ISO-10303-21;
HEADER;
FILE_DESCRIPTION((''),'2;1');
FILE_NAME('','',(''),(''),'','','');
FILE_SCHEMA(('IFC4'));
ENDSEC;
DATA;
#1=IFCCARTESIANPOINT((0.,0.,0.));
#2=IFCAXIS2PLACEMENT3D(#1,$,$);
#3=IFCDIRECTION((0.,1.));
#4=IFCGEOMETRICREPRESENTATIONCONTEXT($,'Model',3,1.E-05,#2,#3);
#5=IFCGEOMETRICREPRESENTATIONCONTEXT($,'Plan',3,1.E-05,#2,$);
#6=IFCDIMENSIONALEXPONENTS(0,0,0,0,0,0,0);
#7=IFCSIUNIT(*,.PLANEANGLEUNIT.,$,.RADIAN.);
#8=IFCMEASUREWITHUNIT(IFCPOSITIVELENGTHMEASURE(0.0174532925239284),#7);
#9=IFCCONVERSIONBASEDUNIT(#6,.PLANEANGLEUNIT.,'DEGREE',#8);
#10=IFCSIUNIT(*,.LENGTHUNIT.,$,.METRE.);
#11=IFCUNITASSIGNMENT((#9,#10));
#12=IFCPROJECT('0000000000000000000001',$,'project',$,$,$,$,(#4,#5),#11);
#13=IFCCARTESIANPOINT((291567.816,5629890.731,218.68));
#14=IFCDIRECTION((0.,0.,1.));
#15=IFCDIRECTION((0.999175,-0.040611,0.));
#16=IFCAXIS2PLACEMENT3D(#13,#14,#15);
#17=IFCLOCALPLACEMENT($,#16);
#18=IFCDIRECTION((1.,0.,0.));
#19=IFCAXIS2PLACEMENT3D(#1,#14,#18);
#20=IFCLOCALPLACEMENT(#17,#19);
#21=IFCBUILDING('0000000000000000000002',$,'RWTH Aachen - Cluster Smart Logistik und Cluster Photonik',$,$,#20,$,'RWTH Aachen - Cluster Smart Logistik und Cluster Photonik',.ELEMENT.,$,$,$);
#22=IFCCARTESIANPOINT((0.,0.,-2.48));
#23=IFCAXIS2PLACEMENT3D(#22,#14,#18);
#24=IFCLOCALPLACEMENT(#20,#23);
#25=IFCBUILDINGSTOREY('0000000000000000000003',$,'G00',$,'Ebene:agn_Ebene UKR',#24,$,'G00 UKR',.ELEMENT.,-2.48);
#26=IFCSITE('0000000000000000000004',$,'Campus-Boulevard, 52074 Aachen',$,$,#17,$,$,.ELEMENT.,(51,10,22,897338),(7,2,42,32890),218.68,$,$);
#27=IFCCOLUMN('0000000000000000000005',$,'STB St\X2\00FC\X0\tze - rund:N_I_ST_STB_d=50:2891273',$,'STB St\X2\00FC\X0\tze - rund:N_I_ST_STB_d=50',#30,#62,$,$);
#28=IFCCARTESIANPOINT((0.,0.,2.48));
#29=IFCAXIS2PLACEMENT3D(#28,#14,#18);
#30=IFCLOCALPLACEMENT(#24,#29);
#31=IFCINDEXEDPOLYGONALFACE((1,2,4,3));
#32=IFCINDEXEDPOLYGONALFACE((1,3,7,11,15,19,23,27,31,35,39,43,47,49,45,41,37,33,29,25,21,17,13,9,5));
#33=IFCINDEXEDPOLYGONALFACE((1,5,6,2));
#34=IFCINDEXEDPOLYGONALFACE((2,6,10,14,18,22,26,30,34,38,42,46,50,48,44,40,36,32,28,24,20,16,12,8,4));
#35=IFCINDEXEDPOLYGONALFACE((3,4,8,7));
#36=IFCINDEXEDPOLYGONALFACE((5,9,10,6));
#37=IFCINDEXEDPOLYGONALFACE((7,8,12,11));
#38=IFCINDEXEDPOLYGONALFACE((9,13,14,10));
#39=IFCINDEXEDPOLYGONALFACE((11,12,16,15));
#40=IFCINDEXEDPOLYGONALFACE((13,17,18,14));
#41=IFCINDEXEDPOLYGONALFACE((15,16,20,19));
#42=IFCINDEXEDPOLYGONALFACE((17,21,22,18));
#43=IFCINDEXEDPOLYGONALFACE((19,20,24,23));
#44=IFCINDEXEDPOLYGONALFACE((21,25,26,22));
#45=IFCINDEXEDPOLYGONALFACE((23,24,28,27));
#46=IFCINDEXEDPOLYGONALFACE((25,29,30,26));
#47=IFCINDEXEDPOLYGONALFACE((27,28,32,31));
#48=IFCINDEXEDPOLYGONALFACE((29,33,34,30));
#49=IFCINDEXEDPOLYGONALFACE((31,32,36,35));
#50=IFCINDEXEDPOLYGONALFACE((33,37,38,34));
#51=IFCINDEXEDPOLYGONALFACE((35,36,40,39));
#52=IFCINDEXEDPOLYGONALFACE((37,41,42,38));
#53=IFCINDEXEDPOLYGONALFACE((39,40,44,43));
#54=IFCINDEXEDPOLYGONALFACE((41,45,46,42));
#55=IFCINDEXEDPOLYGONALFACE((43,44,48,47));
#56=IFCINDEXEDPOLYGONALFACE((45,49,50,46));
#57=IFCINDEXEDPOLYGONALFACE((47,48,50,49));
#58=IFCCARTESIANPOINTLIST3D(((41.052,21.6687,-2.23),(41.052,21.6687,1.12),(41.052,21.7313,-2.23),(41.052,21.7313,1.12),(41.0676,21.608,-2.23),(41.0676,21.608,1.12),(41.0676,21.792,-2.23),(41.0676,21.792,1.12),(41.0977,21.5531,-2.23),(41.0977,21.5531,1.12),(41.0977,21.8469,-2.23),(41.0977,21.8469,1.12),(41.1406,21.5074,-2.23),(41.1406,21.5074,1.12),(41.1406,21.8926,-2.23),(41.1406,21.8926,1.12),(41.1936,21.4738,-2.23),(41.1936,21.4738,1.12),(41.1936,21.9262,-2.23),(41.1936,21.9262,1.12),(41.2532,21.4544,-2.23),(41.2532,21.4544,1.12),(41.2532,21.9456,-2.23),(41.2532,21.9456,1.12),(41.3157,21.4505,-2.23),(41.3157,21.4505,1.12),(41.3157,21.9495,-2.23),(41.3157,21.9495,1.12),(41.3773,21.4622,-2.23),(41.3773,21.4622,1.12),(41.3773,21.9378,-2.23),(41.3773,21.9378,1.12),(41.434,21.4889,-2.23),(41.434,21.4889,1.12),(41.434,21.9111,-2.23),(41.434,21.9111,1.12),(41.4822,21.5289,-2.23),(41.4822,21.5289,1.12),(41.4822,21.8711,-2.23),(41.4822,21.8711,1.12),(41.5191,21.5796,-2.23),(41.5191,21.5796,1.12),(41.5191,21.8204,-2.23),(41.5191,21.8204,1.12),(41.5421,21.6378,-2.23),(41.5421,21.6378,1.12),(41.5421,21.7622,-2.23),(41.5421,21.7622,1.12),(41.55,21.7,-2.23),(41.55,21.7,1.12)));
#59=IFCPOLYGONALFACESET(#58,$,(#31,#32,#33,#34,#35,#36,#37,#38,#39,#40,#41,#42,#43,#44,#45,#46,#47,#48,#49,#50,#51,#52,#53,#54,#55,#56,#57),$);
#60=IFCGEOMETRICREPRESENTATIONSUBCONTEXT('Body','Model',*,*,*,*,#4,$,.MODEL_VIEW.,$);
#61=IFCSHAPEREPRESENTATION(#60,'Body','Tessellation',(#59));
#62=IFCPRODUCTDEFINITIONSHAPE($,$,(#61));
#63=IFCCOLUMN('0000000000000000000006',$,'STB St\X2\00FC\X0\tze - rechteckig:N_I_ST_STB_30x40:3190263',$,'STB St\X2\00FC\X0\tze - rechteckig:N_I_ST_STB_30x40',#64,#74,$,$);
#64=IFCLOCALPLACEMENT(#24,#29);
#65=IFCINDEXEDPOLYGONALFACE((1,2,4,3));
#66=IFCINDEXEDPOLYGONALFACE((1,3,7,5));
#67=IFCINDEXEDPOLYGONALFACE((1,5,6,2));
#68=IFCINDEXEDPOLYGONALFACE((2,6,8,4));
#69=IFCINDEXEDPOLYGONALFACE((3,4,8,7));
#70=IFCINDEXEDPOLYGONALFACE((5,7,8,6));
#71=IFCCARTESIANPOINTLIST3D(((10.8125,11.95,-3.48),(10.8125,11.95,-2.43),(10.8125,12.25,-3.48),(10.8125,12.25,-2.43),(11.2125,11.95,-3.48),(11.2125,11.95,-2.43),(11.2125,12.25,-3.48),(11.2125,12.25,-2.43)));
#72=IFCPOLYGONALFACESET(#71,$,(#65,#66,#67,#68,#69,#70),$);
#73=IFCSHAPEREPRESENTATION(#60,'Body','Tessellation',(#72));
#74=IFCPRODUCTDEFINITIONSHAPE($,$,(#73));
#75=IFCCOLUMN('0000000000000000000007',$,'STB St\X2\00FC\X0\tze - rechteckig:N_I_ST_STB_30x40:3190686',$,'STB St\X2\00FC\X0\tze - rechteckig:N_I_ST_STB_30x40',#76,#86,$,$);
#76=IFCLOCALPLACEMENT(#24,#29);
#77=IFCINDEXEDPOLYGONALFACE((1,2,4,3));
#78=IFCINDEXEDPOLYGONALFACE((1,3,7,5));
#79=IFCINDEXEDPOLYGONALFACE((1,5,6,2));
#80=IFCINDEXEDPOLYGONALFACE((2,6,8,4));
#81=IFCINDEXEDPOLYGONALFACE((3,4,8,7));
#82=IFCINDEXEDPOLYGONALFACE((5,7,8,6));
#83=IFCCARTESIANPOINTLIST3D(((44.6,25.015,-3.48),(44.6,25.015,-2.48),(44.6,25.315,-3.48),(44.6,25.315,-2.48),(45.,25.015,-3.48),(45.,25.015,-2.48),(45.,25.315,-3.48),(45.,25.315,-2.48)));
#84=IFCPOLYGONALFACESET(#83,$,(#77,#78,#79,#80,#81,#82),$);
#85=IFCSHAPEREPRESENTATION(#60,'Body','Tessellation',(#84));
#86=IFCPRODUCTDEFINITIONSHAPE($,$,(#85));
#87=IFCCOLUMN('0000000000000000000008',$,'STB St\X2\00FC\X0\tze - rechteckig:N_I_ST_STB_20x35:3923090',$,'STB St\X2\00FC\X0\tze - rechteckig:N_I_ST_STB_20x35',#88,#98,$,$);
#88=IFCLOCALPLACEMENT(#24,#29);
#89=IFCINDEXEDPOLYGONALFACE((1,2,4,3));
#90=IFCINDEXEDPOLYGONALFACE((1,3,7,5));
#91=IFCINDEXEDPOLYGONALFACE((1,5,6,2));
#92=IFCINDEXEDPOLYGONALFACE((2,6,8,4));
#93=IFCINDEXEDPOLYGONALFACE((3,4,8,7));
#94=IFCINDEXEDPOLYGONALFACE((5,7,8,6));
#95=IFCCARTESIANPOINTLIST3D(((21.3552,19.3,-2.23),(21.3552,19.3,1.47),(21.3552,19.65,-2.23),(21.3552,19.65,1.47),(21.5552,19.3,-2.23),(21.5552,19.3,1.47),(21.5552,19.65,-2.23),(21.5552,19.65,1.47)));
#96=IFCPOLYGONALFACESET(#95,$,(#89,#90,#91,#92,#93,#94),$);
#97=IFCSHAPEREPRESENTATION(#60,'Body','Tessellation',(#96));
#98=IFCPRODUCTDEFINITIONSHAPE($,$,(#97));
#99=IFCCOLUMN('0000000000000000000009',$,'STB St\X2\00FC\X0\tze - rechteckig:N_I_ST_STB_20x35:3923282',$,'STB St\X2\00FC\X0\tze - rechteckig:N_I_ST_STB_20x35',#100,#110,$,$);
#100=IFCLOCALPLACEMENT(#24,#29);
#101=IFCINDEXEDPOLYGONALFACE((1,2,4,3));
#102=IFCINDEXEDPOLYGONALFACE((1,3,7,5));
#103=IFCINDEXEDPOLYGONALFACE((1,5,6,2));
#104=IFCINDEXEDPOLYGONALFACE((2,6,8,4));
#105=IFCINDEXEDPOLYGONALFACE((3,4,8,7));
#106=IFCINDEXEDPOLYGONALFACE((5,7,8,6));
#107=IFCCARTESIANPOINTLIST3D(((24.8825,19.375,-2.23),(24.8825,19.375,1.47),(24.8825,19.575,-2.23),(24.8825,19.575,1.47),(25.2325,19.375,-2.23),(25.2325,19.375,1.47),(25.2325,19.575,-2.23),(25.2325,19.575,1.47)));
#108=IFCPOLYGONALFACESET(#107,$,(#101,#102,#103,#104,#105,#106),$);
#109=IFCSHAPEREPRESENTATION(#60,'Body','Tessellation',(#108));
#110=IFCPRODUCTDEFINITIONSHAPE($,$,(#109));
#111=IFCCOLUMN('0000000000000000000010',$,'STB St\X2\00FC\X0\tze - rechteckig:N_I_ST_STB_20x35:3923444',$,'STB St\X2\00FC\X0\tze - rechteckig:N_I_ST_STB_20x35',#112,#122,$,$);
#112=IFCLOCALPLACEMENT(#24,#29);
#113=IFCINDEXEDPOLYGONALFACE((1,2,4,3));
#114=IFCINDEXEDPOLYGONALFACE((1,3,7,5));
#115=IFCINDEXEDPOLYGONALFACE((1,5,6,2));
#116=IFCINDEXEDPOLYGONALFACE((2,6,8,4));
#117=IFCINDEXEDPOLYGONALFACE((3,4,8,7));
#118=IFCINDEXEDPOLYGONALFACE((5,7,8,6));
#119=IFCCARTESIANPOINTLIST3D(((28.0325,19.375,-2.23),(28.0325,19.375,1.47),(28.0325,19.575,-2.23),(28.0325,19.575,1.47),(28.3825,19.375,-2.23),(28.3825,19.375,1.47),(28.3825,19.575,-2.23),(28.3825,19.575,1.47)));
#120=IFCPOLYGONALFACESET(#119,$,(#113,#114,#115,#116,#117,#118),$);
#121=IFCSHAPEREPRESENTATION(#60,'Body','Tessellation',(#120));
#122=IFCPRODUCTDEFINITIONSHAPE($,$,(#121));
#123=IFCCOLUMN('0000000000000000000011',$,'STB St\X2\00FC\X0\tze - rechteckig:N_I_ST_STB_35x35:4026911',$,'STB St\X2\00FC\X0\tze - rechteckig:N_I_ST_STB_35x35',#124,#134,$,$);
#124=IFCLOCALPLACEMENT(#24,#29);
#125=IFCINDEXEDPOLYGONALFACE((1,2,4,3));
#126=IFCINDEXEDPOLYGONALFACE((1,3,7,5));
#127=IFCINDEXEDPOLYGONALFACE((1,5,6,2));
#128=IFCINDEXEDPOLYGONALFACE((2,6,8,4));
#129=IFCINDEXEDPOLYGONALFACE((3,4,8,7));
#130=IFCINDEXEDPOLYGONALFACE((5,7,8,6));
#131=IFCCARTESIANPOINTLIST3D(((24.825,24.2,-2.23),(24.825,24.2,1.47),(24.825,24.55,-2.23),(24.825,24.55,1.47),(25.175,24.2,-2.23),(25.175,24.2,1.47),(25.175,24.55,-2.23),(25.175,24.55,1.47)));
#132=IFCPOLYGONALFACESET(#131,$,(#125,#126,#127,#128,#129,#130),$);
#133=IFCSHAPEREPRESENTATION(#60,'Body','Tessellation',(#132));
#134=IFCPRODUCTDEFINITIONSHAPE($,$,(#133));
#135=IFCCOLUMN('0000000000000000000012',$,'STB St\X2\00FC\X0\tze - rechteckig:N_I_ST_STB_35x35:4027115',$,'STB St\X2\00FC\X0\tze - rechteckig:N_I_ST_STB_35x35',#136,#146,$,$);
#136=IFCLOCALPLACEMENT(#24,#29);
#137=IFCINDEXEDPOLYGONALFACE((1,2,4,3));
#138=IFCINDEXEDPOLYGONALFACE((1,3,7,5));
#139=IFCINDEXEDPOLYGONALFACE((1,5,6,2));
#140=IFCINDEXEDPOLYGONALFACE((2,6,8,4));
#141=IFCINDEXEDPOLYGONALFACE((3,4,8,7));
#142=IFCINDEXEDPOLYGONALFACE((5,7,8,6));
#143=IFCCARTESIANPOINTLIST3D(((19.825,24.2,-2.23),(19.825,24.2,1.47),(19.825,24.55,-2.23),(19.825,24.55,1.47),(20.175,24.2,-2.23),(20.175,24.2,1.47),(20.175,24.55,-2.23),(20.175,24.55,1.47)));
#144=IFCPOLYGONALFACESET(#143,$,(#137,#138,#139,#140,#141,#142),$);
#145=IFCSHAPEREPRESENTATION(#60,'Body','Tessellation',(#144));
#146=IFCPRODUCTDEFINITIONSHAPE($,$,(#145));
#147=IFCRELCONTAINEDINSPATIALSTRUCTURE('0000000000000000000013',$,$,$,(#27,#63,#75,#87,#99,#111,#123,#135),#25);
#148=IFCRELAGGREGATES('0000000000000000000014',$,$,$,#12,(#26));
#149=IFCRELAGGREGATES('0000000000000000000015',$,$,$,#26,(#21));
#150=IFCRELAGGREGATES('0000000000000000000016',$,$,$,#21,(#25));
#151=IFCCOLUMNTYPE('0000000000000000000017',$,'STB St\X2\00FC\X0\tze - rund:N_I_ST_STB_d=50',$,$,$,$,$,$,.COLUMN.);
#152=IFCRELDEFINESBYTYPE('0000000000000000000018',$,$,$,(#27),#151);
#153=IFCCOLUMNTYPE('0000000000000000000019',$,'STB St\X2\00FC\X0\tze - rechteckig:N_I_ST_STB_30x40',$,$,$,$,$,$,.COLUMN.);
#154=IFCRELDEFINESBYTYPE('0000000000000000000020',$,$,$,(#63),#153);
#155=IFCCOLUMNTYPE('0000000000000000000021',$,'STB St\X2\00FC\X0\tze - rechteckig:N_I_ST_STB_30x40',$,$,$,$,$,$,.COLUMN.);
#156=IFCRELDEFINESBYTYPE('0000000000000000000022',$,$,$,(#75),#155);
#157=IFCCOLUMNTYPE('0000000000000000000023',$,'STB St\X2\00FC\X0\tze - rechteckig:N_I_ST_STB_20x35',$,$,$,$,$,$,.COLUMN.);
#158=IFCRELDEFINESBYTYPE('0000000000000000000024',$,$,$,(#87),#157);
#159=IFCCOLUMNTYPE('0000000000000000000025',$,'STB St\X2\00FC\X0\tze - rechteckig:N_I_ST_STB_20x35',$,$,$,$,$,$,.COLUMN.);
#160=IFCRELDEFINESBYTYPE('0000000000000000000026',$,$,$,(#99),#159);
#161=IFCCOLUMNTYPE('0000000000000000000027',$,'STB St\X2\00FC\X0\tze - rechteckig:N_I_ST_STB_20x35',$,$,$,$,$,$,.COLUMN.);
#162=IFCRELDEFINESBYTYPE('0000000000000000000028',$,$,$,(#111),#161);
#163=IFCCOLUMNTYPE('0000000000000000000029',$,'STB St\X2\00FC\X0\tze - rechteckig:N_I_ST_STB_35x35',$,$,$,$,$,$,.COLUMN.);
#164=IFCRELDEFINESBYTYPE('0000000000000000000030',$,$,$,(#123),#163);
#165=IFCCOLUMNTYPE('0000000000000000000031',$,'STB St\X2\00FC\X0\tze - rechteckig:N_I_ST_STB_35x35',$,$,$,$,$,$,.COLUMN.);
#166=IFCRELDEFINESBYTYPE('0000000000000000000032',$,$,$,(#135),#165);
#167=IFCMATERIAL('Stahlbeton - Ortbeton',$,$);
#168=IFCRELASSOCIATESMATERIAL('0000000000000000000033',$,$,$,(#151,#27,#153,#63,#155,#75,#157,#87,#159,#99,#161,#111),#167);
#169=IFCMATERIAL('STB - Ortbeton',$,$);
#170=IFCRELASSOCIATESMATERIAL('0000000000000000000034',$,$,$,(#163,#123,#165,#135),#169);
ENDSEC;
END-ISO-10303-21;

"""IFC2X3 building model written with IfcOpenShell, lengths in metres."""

from ifc_helpers import new_model, entity, si_unit, converted_unit, direction, frame, frame_2d, origin, origin_with_axes, origin_2d_with_axis, place, context, subcontext, project, spatial, rectangle, circle, extrude, source, transform, mapped, material, type_object, element, save


model = new_model("IFC2X3")

# Units and contexts
model_context = context("Model", 3, precision=1e-05, world=origin(), true_north=direction((0.0, 1.0)))
plan_context = context("Plan", 3, precision=1e-05, world=origin())
body_context = subcontext(model_context, "Body", "Model", "MODEL_VIEW")
ifc_project = project(units=[converted_unit("PLANEANGLEUNIT", "DEGREE", entity("IfcPositiveLengthMeasure", 0.0174532925239284), si_unit("PLANEANGLEUNIT", "RADIAN"), dimensions=[0, 0, 0, 0, 0, 0, 0]), si_unit("LENGTHUNIT", "METRE")], contexts=[model_context, plan_context])

# Site, building, storey
site_placement = place(None, frame((291567.816, 5629890.731, 218.68), z_axis=(0.0, 0.0, 1.0), x_axis=(0.999175, -0.040611, 0.0)))
site = spatial("IfcSite", under=ifc_project, at=site_placement, Name="Campus-Boulevard, 52074 Aachen", CompositionType="ELEMENT", RefLatitude=(51, 10, 22, 897338), RefLongitude=(7, 2, 42, 32890), RefElevation=218.68)
building_placement = place(site_placement, origin_with_axes())
building = spatial("IfcBuilding", under=site, at=building_placement, Name="RWTH Aachen - Cluster Smart Logistik und Cluster Photonik", LongName="RWTH Aachen - Cluster Smart Logistik und Cluster Photonik", CompositionType="ELEMENT")
storey_placement = place(building_placement, frame((0.0, 0.0, -2.48), z_axis=(0.0, 0.0, 1.0), x_axis=(1.0, 0.0, 0.0)))
storey = spatial("IfcBuildingStorey", under=building, at=storey_placement, Name="G00", ObjectType="Ebene:agn_Ebene UKR", LongName="G00 UKR", CompositionType="ELEMENT", Elevation=-2.48)

# Shared definitions
ifc_material_1 = material(Name="STB - Ortbeton")

# Columns
ifc_material_2 = material(Name="Stahlbeton - Ortbeton")
column_type_1 = type_object("IfcColumnType", Name="STB Stütze - rund:N_I_ST_STB_d=50", PredefinedType="COLUMN", material=ifc_material_2)
shared_shape_1 = source(origin(), body_context, "Body", "SweptSolid", [
    extrude(circle(Radius=0.25, at=origin_2d_with_axis()), frame((41.3, 21.7, -2.23)), (0.0, 0.0, 1.0), 3.35),
])
column_1_placement = place(storey_placement, frame((0.0, 0.0, 2.48), z_axis=(0.0, 0.0, 1.0), x_axis=(1.0, 0.0, 0.0)))
element("IfcColumn", 1, at=column_1_placement, inside=storey, type_object=column_type_1, material=ifc_material_2, Name="STB Stütze - rund:N_I_ST_STB_d=50:2891273", ObjectType="STB Stütze - rund:N_I_ST_STB_d=50", context=body_context, shape_type="MappedRepresentation", body=[
    mapped(shared_shape_1, transform((0.0, 0.0, 0.0), scale=1.0)),
])
column_type_2 = type_object("IfcColumnType", Name="STB Stütze - rechteckig:N_I_ST_STB_30x40", PredefinedType="COLUMN", material=ifc_material_2)
shared_shape_2 = source(origin(), body_context, "Body", "SweptSolid", [
    extrude(rectangle(XDim=0.3, YDim=0.4, at=origin_2d_with_axis()), frame((11.0125, 12.1, -3.48), z_axis=(0.0, 0.0, 1.0), x_axis=(0.0, -1.0, 0.0)), (0.0, 0.0, 1.0), 1.05),
])
column_2_placement = place(storey_placement, frame((0.0, 0.0, 2.48), z_axis=(0.0, 0.0, 1.0), x_axis=(1.0, 0.0, 0.0)))
element("IfcColumn", 2, at=column_2_placement, inside=storey, type_object=column_type_2, material=ifc_material_2, Name="STB Stütze - rechteckig:N_I_ST_STB_30x40:3190263", ObjectType="STB Stütze - rechteckig:N_I_ST_STB_30x40", context=body_context, shape_type="MappedRepresentation", body=[
    mapped(shared_shape_2, transform((0.0, 0.0, 0.0), scale=1.0)),
])
column_type_3 = type_object("IfcColumnType", Name="STB Stütze - rechteckig:N_I_ST_STB_30x40", PredefinedType="COLUMN", material=ifc_material_2)
shared_shape_3 = source(origin(), body_context, "Body", "SweptSolid", [
    extrude(rectangle(XDim=0.3, YDim=0.4, at=origin_2d_with_axis()), frame((44.8, 25.165, -3.48), z_axis=(0.0, 0.0, 1.0), x_axis=(0.0, -1.0, 0.0)), (0.0, 0.0, 1.0), 1.0),
])
column_3_placement = place(storey_placement, frame((0.0, 0.0, 2.48), z_axis=(0.0, 0.0, 1.0), x_axis=(1.0, 0.0, 0.0)))
element("IfcColumn", 3, at=column_3_placement, inside=storey, type_object=column_type_3, material=ifc_material_2, Name="STB Stütze - rechteckig:N_I_ST_STB_30x40:3190686", ObjectType="STB Stütze - rechteckig:N_I_ST_STB_30x40", context=body_context, shape_type="MappedRepresentation", body=[
    mapped(shared_shape_3, transform((0.0, 0.0, 0.0), scale=1.0)),
])
column_type_4 = type_object("IfcColumnType", Name="STB Stütze - rechteckig:N_I_ST_STB_20x35", PredefinedType="COLUMN", material=ifc_material_2)
shared_shape_4 = source(origin(), body_context, "Body", "SweptSolid", [
    extrude(rectangle(XDim=0.35, YDim=0.2, at=origin_2d_with_axis()), frame((21.4552, 19.475, -2.23), z_axis=(0.0, 0.0, 1.0), x_axis=(0.0, -1.0, 0.0)), (0.0, 0.0, 1.0), 3.7),
])
column_4_placement = place(storey_placement, frame((0.0, 0.0, 2.48), z_axis=(0.0, 0.0, 1.0), x_axis=(1.0, 0.0, 0.0)))
element("IfcColumn", 4, at=column_4_placement, inside=storey, type_object=column_type_4, material=ifc_material_2, Name="STB Stütze - rechteckig:N_I_ST_STB_20x35:3923090", ObjectType="STB Stütze - rechteckig:N_I_ST_STB_20x35", context=body_context, shape_type="MappedRepresentation", body=[
    mapped(shared_shape_4, transform((0.0, 0.0, 0.0), scale=1.0)),
])
column_type_5 = type_object("IfcColumnType", Name="STB Stütze - rechteckig:N_I_ST_STB_20x35", PredefinedType="COLUMN", material=ifc_material_2)
shared_shape_5 = source(origin(), body_context, "Body", "SweptSolid", [
    extrude(rectangle(XDim=0.2, YDim=0.35, at=origin_2d_with_axis()), frame((25.0575, 19.475, -2.23), z_axis=(0.0, 0.0, 1.0), x_axis=(0.0, -1.0, 0.0)), (0.0, 0.0, 1.0), 3.7),
])
column_5_placement = place(storey_placement, frame((0.0, 0.0, 2.48), z_axis=(0.0, 0.0, 1.0), x_axis=(1.0, 0.0, 0.0)))
element("IfcColumn", 5, at=column_5_placement, inside=storey, type_object=column_type_5, material=ifc_material_2, Name="STB Stütze - rechteckig:N_I_ST_STB_20x35:3923282", ObjectType="STB Stütze - rechteckig:N_I_ST_STB_20x35", context=body_context, shape_type="MappedRepresentation", body=[
    mapped(shared_shape_5, transform((0.0, 0.0, 0.0), scale=1.0)),
])
column_type_6 = type_object("IfcColumnType", Name="STB Stütze - rechteckig:N_I_ST_STB_20x35", PredefinedType="COLUMN", material=ifc_material_2)
shared_shape_6 = source(origin(), body_context, "Body", "SweptSolid", [
    extrude(rectangle(XDim=0.2, YDim=0.35, at=frame_2d((0.0, 0.0), x_axis=(1.0, 0.0))), frame((28.2075, 19.475, -2.23), z_axis=(0.0, 0.0, 1.0), x_axis=(0.0, -1.0, 0.0)), (0.0, 0.0, 1.0), 3.7),
])
column_6_placement = place(storey_placement, frame((0.0, 0.0, 2.48), z_axis=(0.0, 0.0, 1.0), x_axis=(1.0, 0.0, 0.0)))
element("IfcColumn", 6, at=column_6_placement, inside=storey, type_object=column_type_6, material=ifc_material_2, Name="STB Stütze - rechteckig:N_I_ST_STB_20x35:3923444", ObjectType="STB Stütze - rechteckig:N_I_ST_STB_20x35", context=body_context, shape_type="MappedRepresentation", body=[
    mapped(shared_shape_6, transform((0.0, 0.0, 0.0), scale=1.0)),
])
column_type_7 = type_object("IfcColumnType", Name="STB Stütze - rechteckig:N_I_ST_STB_35x35", PredefinedType="COLUMN", material=ifc_material_1)
shared_shape_7 = source(origin(), body_context, "Body", "SweptSolid", [
    extrude(rectangle(XDim=0.35, YDim=0.35, at=origin_2d_with_axis()), frame((25.0, 24.375, -2.23), z_axis=(0.0, 0.0, 1.0), x_axis=(0.0, -1.0, 0.0)), (0.0, 0.0, 1.0), 3.7),
])
column_7_placement = place(storey_placement, frame((0.0, 0.0, 2.48), z_axis=(0.0, 0.0, 1.0), x_axis=(1.0, 0.0, 0.0)))
element("IfcColumn", 7, at=column_7_placement, inside=storey, type_object=column_type_7, material=ifc_material_1, Name="STB Stütze - rechteckig:N_I_ST_STB_35x35:4026911", ObjectType="STB Stütze - rechteckig:N_I_ST_STB_35x35", context=body_context, shape_type="MappedRepresentation", body=[
    mapped(shared_shape_7, transform((0.0, 0.0, 0.0), scale=1.0)),
])
column_type_8 = type_object("IfcColumnType", Name="STB Stütze - rechteckig:N_I_ST_STB_35x35", PredefinedType="COLUMN", material=ifc_material_1)
shared_shape_8 = source(origin(), body_context, "Body", "SweptSolid", [
    extrude(rectangle(XDim=0.35, YDim=0.35, at=origin_2d_with_axis()), frame((20.0, 24.375, -2.23), z_axis=(0.0, 0.0, 1.0), x_axis=(0.0, -1.0, 0.0)), (0.0, 0.0, 1.0), 3.7),
])
column_8_placement = place(storey_placement, frame((0.0, 0.0, 2.48), z_axis=(0.0, 0.0, 1.0), x_axis=(1.0, 0.0, 0.0)))
element("IfcColumn", 8, at=column_8_placement, inside=storey, type_object=column_type_8, material=ifc_material_1, Name="STB Stütze - rechteckig:N_I_ST_STB_35x35:4027115", ObjectType="STB Stütze - rechteckig:N_I_ST_STB_35x35", context=body_context, shape_type="MappedRepresentation", body=[
    mapped(shared_shape_8, transform((0.0, 0.0, 0.0), scale=1.0)),
])

save(model, "model.ifc")
